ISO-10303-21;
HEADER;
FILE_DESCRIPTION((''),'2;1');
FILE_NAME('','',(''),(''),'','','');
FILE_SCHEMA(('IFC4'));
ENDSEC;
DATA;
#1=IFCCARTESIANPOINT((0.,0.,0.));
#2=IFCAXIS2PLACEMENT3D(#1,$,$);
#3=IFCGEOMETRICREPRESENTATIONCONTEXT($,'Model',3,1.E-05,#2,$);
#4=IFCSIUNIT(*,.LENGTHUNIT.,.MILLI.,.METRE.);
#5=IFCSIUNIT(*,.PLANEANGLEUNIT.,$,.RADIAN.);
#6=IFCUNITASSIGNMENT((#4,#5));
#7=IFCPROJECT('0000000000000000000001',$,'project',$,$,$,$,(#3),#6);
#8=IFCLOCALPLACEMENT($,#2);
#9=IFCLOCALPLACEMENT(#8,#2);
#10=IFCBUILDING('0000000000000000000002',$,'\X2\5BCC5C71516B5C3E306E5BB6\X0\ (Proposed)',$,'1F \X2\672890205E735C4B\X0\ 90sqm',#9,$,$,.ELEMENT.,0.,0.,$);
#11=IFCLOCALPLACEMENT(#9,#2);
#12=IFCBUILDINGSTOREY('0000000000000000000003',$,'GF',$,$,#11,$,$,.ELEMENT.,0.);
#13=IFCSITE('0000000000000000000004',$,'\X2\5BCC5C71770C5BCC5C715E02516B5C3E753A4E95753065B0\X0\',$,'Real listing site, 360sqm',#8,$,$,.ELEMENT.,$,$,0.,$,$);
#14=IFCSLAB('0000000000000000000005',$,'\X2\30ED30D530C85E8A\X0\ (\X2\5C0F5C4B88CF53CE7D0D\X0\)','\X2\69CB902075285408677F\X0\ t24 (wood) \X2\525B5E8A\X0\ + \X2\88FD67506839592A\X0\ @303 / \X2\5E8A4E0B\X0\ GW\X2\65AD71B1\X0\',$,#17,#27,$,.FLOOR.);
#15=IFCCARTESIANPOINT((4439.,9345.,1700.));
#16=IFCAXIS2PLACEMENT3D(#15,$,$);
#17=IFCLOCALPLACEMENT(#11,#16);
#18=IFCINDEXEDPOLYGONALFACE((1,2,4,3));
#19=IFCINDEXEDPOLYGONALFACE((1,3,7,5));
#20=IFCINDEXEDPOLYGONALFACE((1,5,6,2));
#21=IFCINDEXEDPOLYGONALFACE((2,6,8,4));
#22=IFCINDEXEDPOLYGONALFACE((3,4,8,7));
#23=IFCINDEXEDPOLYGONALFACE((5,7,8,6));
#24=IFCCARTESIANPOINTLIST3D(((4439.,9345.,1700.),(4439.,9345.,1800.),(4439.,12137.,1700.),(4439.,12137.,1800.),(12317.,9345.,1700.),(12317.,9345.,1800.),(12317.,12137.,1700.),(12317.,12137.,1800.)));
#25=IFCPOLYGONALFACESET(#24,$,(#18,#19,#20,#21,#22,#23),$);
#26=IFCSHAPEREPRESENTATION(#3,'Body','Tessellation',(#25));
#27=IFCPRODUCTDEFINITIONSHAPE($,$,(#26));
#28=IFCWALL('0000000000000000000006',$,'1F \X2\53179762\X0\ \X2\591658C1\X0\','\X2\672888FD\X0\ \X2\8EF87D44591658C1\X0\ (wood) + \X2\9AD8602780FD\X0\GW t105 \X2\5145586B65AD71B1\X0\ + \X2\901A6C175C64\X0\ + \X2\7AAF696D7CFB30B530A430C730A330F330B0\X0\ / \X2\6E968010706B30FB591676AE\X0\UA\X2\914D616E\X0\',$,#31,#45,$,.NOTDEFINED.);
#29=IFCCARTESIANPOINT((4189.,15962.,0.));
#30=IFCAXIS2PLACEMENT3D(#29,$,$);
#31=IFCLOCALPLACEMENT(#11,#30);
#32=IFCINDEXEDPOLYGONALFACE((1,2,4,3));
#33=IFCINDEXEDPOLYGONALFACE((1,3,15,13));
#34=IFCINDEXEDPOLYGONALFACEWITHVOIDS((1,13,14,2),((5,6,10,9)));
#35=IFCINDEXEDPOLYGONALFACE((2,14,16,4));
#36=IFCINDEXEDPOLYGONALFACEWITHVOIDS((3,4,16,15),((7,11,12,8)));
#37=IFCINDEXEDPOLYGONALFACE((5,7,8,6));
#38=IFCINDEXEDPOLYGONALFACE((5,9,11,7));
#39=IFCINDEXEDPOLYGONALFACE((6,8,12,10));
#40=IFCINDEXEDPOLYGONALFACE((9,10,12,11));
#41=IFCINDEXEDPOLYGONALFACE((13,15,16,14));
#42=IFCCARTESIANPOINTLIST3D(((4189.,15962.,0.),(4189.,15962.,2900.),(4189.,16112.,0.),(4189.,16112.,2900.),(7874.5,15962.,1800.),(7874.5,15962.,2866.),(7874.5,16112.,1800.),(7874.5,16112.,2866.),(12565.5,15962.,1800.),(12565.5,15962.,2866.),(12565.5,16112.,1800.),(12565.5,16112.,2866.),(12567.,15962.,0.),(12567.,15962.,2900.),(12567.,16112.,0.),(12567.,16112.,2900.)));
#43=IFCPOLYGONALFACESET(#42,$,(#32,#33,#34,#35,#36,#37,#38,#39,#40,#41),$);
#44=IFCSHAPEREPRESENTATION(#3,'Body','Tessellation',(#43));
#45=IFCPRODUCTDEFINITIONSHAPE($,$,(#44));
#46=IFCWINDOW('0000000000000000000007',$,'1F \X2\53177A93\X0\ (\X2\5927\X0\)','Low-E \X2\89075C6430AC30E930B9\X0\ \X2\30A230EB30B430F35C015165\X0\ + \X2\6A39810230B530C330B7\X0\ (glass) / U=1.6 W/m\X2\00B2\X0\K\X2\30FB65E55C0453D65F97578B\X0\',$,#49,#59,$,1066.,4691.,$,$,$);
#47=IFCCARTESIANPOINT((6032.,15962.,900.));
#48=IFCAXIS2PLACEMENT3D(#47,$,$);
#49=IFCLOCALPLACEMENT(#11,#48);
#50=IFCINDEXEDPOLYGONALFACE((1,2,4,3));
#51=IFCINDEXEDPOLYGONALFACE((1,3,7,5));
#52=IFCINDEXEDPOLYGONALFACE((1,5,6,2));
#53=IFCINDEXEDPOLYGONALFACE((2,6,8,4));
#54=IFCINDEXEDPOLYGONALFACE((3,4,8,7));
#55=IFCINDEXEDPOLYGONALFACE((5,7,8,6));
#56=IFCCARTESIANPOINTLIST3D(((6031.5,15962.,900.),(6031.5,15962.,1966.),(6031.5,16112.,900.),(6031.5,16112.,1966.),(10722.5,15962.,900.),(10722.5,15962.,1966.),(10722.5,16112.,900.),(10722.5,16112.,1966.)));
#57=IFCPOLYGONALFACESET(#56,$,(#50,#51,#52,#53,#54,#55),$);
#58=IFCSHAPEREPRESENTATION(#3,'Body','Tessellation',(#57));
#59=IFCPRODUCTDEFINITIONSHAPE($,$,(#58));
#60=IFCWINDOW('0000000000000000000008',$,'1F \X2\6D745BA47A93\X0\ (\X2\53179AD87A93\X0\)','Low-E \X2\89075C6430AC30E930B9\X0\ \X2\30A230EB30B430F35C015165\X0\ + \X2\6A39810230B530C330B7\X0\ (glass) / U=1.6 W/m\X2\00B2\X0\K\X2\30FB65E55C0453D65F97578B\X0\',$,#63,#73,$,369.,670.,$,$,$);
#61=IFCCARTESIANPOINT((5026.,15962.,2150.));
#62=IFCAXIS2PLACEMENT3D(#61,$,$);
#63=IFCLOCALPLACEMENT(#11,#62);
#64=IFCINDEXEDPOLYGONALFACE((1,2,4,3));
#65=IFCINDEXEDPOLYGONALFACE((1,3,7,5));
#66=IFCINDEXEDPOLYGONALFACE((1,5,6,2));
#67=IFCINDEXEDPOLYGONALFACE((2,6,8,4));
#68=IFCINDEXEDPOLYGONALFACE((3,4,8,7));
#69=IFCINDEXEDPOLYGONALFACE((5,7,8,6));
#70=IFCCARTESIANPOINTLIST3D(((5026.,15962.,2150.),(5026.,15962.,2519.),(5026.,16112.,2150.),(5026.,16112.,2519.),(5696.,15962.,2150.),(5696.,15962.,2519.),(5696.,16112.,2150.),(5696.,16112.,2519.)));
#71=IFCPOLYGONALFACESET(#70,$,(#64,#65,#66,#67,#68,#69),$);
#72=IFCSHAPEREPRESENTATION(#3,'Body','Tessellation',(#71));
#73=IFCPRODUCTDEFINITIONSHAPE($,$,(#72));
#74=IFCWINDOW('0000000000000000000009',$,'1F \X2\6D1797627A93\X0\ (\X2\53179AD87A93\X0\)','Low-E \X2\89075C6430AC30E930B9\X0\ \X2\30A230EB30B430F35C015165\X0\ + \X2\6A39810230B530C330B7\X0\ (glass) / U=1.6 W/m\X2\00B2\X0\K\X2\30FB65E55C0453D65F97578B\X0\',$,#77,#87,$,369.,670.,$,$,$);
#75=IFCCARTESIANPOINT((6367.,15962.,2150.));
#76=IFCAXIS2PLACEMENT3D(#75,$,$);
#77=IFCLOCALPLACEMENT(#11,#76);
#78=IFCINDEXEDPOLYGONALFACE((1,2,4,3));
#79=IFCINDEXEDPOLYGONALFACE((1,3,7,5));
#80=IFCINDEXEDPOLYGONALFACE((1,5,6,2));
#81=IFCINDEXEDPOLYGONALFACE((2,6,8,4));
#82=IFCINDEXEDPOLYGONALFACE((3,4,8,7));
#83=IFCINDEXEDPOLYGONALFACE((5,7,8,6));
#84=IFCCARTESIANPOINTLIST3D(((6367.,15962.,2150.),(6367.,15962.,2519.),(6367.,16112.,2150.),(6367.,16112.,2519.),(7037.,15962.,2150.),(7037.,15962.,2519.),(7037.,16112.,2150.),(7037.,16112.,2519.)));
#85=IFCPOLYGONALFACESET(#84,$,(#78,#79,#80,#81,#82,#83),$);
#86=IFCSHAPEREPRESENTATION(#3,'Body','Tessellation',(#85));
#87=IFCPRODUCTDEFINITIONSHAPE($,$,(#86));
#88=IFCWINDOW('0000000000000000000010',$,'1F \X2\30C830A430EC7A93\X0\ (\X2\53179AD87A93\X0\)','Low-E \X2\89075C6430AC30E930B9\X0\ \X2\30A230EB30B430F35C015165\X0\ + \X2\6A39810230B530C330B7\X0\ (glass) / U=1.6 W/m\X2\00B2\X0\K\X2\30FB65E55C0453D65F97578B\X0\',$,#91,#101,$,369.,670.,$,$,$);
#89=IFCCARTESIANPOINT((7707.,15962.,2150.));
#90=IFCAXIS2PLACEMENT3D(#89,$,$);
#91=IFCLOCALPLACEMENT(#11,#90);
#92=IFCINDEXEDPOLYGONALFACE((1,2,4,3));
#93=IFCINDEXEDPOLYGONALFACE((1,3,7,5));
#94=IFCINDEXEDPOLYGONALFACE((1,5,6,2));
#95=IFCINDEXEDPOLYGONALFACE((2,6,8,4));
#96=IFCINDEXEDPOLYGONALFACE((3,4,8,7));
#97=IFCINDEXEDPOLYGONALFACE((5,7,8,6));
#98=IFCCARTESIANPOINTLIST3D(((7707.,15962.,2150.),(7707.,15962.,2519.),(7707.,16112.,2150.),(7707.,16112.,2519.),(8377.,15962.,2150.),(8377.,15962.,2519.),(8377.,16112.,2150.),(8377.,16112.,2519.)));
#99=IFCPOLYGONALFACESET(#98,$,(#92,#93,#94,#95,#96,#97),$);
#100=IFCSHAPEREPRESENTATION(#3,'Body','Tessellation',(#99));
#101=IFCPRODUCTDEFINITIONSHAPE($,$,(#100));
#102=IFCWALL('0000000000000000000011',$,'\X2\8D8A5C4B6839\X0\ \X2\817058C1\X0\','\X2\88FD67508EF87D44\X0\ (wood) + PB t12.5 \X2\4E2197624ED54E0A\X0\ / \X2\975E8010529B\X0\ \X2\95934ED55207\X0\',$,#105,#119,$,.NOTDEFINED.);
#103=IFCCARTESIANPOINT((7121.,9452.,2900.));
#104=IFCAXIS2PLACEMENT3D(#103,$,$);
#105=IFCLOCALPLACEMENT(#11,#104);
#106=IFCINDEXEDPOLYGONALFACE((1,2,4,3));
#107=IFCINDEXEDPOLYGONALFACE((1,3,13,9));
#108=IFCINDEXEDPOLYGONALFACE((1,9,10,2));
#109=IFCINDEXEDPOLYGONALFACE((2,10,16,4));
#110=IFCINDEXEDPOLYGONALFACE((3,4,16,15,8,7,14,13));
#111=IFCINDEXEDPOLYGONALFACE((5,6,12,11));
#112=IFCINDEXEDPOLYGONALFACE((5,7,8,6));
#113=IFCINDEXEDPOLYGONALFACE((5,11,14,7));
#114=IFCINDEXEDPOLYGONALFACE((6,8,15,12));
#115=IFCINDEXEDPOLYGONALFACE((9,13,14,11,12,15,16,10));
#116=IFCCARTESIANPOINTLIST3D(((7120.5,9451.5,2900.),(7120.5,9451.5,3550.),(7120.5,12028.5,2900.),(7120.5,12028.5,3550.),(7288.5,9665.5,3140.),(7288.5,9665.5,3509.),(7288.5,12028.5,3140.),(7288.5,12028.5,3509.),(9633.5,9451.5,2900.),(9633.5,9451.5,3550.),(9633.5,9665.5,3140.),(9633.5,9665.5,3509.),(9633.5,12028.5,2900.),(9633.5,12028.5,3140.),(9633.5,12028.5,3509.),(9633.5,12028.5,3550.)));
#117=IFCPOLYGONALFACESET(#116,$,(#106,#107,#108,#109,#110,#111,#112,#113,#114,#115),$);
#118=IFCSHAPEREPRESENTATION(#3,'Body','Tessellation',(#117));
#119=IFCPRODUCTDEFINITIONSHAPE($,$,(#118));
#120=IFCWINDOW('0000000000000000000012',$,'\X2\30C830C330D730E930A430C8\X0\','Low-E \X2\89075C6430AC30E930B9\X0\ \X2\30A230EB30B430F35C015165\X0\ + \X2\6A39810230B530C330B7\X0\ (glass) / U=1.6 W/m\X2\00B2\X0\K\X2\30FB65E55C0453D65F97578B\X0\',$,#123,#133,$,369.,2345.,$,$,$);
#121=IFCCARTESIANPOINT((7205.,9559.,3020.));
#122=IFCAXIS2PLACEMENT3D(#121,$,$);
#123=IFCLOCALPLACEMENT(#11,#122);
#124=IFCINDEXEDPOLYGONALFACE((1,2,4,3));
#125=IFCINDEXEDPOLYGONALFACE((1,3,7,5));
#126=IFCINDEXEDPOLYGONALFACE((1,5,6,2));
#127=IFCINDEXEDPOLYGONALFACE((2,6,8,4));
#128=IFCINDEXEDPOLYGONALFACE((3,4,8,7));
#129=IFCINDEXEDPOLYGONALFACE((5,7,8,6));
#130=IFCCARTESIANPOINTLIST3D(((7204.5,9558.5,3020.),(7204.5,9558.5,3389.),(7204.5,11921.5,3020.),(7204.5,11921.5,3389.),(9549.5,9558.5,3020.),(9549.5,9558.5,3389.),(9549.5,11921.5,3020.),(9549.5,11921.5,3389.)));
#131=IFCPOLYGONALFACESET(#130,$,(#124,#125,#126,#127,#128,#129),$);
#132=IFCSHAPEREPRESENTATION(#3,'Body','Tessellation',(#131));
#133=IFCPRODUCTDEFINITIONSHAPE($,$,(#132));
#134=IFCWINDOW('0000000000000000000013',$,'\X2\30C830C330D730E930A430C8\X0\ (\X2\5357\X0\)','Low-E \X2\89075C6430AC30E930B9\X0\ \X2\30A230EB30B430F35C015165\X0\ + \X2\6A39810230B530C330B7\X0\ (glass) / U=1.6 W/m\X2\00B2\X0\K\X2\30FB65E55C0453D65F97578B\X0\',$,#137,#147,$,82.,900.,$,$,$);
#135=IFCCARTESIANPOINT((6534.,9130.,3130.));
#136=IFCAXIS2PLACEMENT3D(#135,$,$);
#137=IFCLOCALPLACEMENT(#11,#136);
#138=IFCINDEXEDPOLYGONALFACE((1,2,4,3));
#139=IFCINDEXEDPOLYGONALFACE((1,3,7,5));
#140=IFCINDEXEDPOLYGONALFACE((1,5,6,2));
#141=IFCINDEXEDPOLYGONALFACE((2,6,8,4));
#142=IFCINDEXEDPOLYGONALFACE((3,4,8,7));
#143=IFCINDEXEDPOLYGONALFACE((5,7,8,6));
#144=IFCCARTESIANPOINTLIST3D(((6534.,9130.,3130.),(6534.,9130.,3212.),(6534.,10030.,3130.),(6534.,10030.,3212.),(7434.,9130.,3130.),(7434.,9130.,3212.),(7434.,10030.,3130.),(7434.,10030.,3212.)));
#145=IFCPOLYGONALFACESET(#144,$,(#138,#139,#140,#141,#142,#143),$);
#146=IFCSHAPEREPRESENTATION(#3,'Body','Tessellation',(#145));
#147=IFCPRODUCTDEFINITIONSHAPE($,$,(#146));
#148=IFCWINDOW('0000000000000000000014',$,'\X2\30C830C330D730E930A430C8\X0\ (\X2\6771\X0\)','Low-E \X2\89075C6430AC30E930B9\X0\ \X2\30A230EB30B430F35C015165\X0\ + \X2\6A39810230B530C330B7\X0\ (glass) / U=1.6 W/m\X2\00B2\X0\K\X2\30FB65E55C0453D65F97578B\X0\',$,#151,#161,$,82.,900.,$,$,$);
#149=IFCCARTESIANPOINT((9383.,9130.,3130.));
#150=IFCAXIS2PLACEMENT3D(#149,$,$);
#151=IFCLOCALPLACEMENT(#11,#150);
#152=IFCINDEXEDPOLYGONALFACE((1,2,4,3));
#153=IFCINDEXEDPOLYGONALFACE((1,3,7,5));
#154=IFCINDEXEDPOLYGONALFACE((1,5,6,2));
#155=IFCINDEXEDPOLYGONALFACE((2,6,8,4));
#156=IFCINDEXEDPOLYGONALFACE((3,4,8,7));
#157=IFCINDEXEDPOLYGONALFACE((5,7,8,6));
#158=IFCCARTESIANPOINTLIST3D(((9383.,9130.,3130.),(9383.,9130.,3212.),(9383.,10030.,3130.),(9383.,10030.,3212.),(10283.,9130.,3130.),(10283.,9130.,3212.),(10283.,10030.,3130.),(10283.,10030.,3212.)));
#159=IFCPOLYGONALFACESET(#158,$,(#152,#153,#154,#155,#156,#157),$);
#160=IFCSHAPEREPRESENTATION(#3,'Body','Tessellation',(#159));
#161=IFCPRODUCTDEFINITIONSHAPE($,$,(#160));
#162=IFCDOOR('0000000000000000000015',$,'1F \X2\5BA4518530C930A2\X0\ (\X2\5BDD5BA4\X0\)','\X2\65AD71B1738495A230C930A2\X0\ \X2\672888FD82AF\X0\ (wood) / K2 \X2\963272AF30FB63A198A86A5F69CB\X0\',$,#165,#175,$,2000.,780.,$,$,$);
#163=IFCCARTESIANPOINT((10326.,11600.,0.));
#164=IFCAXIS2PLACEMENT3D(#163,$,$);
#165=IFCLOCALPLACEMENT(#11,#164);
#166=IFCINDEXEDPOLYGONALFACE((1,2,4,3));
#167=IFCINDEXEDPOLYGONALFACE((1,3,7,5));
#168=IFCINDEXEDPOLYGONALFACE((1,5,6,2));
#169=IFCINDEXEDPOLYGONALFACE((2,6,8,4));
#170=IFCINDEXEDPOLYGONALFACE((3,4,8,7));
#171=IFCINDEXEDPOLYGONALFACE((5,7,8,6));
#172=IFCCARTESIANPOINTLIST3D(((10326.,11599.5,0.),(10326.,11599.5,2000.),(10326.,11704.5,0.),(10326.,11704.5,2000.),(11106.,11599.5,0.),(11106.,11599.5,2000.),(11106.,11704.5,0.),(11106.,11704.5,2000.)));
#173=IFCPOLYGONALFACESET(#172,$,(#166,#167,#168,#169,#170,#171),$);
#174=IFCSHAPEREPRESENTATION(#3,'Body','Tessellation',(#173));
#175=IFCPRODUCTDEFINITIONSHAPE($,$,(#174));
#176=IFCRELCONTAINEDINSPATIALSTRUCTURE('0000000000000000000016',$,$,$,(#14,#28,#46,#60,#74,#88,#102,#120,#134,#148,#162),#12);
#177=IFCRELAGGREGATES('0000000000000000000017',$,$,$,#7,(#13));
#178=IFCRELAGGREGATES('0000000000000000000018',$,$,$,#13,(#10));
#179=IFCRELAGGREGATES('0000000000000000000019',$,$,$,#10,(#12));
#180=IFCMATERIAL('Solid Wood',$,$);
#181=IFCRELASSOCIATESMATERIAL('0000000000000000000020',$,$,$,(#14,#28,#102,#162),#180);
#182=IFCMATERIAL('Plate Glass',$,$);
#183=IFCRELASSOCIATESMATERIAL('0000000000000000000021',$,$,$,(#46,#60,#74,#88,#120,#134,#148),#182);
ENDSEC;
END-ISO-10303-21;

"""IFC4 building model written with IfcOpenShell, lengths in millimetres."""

from ifc_helpers import new_model, si_unit, frame, frame_2d, origin, place, context, project, spatial, rectangle, extrude, material, element, fill, save


model = new_model("IFC4")

# Units and contexts
model_context = context("Model", 3, precision=1e-05, world=origin())
ifc_project = project(units=[si_unit("LENGTHUNIT", "METRE", prefix="MILLI"), si_unit("PLANEANGLEUNIT", "RADIAN")], contexts=[model_context])

# Site, building, storey
site_placement = place(None, origin())
site = spatial("IfcSite", under=ifc_project, at=site_placement, Name="富山県富山市八尾町井田新", ObjectType="Real listing site, 360sqm", CompositionType="ELEMENT", RefElevation=0.0)
building_placement = place(site_placement, origin())
building = spatial("IfcBuilding", under=site, at=building_placement, Name="富山八尾の家 (Proposed)", ObjectType="1F 木造平屋 90sqm", CompositionType="ELEMENT", ElevationOfRefHeight=0.0, ElevationOfTerrain=0.0)
storey_placement = place(building_placement, origin())
storey = spatial("IfcBuildingStorey", under=building, at=storey_placement, Name="GF", CompositionType="ELEMENT", Elevation=0.0)

# Slab
ifc_material_1 = material(Name="Solid Wood")
slab_placement = place(storey_placement, frame((4439.0, 9345.0, 1700.0)))
element("IfcSlab", 1, at=slab_placement, inside=storey, material=ifc_material_1, Name="ロフト床 (小屋裏収納)", Description="構造用合板 t24 (wood) 剛床 + 製材根太 @303 / 床下 GW断熱", PredefinedType="FLOOR", context=model_context, shape_type="SweptSolid", body=[
    extrude(rectangle(XDim=7878.0, YDim=2792.0, at=frame_2d((3939.0, 1396.0))), frame((4439.0, 9345.0, 1700.0)), (0.0, 0.0, 1.0), 100.0),
])

# Wall, openings, windows
wall_1_placement = place(storey_placement, frame((4189.0, 15962.0, 0.0)))
wall_1 = element("IfcWall", 2, at=wall_1_placement, inside=storey, material=ifc_material_1, Name="1F 北面 外壁", Description="木製 軸組外壁 (wood) + 高性能GW t105 充填断熱 + 通気層 + 窯業系サイディング / 準耐火・外皮UA配慮", PredefinedType="NOTDEFINED", context=model_context, shape_type="SweptSolid", body=[
    extrude(rectangle(XDim=8378.0, YDim=150.0, at=frame_2d((4189.0, 75.0))), frame((4189.0, 15962.0, 0.0)), (0.0, 0.0, 1.0), 2900.0),
])
opening_1_placement = place(storey_placement, frame((6032.0, 15962.0, 900.0)))
opening_1 = element("IfcOpeningElement", 3, at=opening_1_placement, cuts=wall_1, PredefinedType="NOTDEFINED", context=model_context, shape_type="SweptSolid", body=[
    extrude(rectangle(XDim=4691.0, YDim=150.0, at=frame_2d((2345.0, 75.0))), frame((6032.0, 15962.0, 900.0)), (0.0, 0.0, 1.0), 1066.0),
])
opening_2_placement = place(storey_placement, frame((5026.0, 15962.0, 2150.0)))
opening_2 = element("IfcOpeningElement", 4, at=opening_2_placement, cuts=wall_1, PredefinedType="NOTDEFINED", context=model_context, shape_type="SweptSolid", body=[
    extrude(rectangle(XDim=670.0, YDim=150.0, at=frame_2d((335.0, 75.0))), frame((5026.0, 15962.0, 2150.0)), (0.0, 0.0, 1.0), 369.0),
])
opening_3_placement = place(storey_placement, frame((6367.0, 15962.0, 2150.0)))
opening_3 = element("IfcOpeningElement", 5, at=opening_3_placement, cuts=wall_1, PredefinedType="NOTDEFINED", context=model_context, shape_type="SweptSolid", body=[
    extrude(rectangle(XDim=670.0, YDim=150.0, at=frame_2d((335.0, 75.0))), frame((6367.0, 15962.0, 2150.0)), (0.0, 0.0, 1.0), 369.0),
])
opening_4_placement = place(storey_placement, frame((7707.0, 15962.0, 2150.0)))
opening_4 = element("IfcOpeningElement", 6, at=opening_4_placement, cuts=wall_1, PredefinedType="NOTDEFINED", context=model_context, shape_type="SweptSolid", body=[
    extrude(rectangle(XDim=670.0, YDim=150.0, at=frame_2d((335.0, 75.0))), frame((7707.0, 15962.0, 2150.0)), (0.0, 0.0, 1.0), 369.0),
])
ifc_material_2 = material(Name="Plate Glass")
window_1_placement = place(storey_placement, frame((6032.0, 15962.0, 900.0)))
window_1 = element("IfcWindow", 7, at=window_1_placement, inside=storey, material=ifc_material_2, Name="1F 北窓 (大)", Description="Low-E 複層ガラス アルゴン封入 + 樹脂サッシ (glass) / U=1.6 W/m²K・日射取得型", OverallHeight=1066.0, OverallWidth=4691.0, context=model_context, shape_type="SweptSolid", body=[
    extrude(rectangle(XDim=4691.0, YDim=150.0, at=frame_2d((2345.0, 75.0))), frame((6032.0, 15962.0, 900.0)), (0.0, 0.0, 1.0), 1066.0),
])
fill(opening_1, window_1)
window_2_placement = place(storey_placement, frame((5026.0, 15962.0, 2150.0)))
window_2 = element("IfcWindow", 8, at=window_2_placement, inside=storey, material=ifc_material_2, Name="1F 浴室窓 (北高窓)", Description="Low-E 複層ガラス アルゴン封入 + 樹脂サッシ (glass) / U=1.6 W/m²K・日射取得型", OverallHeight=369.0, OverallWidth=670.0, context=model_context, shape_type="SweptSolid", body=[
    extrude(rectangle(XDim=670.0, YDim=150.0, at=frame_2d((335.0, 75.0))), frame((5026.0, 15962.0, 2150.0)), (0.0, 0.0, 1.0), 369.0),
])
fill(opening_2, window_2)
window_3_placement = place(storey_placement, frame((6367.0, 15962.0, 2150.0)))
window_3 = element("IfcWindow", 9, at=window_3_placement, inside=storey, material=ifc_material_2, Name="1F 洗面窓 (北高窓)", Description="Low-E 複層ガラス アルゴン封入 + 樹脂サッシ (glass) / U=1.6 W/m²K・日射取得型", OverallHeight=369.0, OverallWidth=670.0, context=model_context, shape_type="SweptSolid", body=[
    extrude(rectangle(XDim=670.0, YDim=150.0, at=frame_2d((335.0, 75.0))), frame((6367.0, 15962.0, 2150.0)), (0.0, 0.0, 1.0), 369.0),
])
fill(opening_3, window_3)
window_4_placement = place(storey_placement, frame((7707.0, 15962.0, 2150.0)))
window_4 = element("IfcWindow", 10, at=window_4_placement, inside=storey, material=ifc_material_2, Name="1F トイレ窓 (北高窓)", Description="Low-E 複層ガラス アルゴン封入 + 樹脂サッシ (glass) / U=1.6 W/m²K・日射取得型", OverallHeight=369.0, OverallWidth=670.0, context=model_context, shape_type="SweptSolid", body=[
    extrude(rectangle(XDim=670.0, YDim=150.0, at=frame_2d((335.0, 75.0))), frame((7707.0, 15962.0, 2150.0)), (0.0, 0.0, 1.0), 369.0),
])
fill(opening_4, window_4)

# Wall, openings, windows
wall_2_placement = place(storey_placement, frame((7121.0, 9452.0, 2900.0)))
wall_2 = element("IfcWall", 11, at=wall_2_placement, inside=storey, material=ifc_material_1, Name="越屋根 腰壁", Description="製材軸組 (wood) + PB t12.5 両面仕上 / 非耐力 間仕切", PredefinedType="NOTDEFINED", context=model_context, shape_type="SweptSolid", body=[
    extrude(rectangle(XDim=2513.0, YDim=2577.0, at=frame_2d((1256.0, 1288.0))), frame((7121.0, 9452.0, 2900.0)), (0.0, 0.0, 1.0), 650.0),
])
opening_5_placement = place(storey_placement, frame((7205.0, 9559.0, 3020.0)))
opening_5 = element("IfcOpeningElement", 12, at=opening_5_placement, cuts=wall_2, PredefinedType="NOTDEFINED", context=model_context, shape_type="SweptSolid", body=[
    extrude(rectangle(XDim=2345.0, YDim=2363.0, at=frame_2d((1172.0, 1181.0))), frame((7205.0, 9559.0, 3020.0)), (0.0, 0.0, 1.0), 369.0),
])
opening_6_placement = place(storey_placement, frame((6534.0, 9130.0, 3130.0)))
opening_6 = element("IfcOpeningElement", 13, at=opening_6_placement, cuts=wall_2, PredefinedType="NOTDEFINED", context=model_context, shape_type="SweptSolid", body=[
    extrude(rectangle(XDim=900.0, YDim=900.0, at=frame_2d((450.0, 450.0))), frame((6534.0, 9130.0, 3130.0)), (0.0, 0.0, 1.0), 82.0),
])
opening_7_placement = place(storey_placement, frame((9383.0, 9130.0, 3130.0)))
opening_7 = element("IfcOpeningElement", 14, at=opening_7_placement, cuts=wall_2, PredefinedType="NOTDEFINED", context=model_context, shape_type="SweptSolid", body=[
    extrude(rectangle(XDim=900.0, YDim=900.0, at=frame_2d((450.0, 450.0))), frame((9383.0, 9130.0, 3130.0)), (0.0, 0.0, 1.0), 82.0),
])
window_5_placement = place(storey_placement, frame((7205.0, 9559.0, 3020.0)))
window_5 = element("IfcWindow", 15, at=window_5_placement, inside=storey, material=ifc_material_2, Name="トップライト", Description="Low-E 複層ガラス アルゴン封入 + 樹脂サッシ (glass) / U=1.6 W/m²K・日射取得型", OverallHeight=369.0, OverallWidth=2345.0, context=model_context, shape_type="SweptSolid", body=[
    extrude(rectangle(XDim=2345.0, YDim=2363.0, at=frame_2d((1172.0, 1181.0))), frame((7205.0, 9559.0, 3020.0)), (0.0, 0.0, 1.0), 369.0),
])
fill(opening_5, window_5)
window_6_placement = place(storey_placement, frame((6534.0, 9130.0, 3130.0)))
window_6 = element("IfcWindow", 16, at=window_6_placement, inside=storey, material=ifc_material_2, Name="トップライト (南)", Description="Low-E 複層ガラス アルゴン封入 + 樹脂サッシ (glass) / U=1.6 W/m²K・日射取得型", OverallHeight=82.0, OverallWidth=900.0, context=model_context, shape_type="SweptSolid", body=[
    extrude(rectangle(XDim=900.0, YDim=900.0, at=frame_2d((450.0, 450.0))), frame((6534.0, 9130.0, 3130.0)), (0.0, 0.0, 1.0), 82.0),
])
fill(opening_6, window_6)
window_7_placement = place(storey_placement, frame((9383.0, 9130.0, 3130.0)))
window_7 = element("IfcWindow", 17, at=window_7_placement, inside=storey, material=ifc_material_2, Name="トップライト (東)", Description="Low-E 複層ガラス アルゴン封入 + 樹脂サッシ (glass) / U=1.6 W/m²K・日射取得型", OverallHeight=82.0, OverallWidth=900.0, context=model_context, shape_type="SweptSolid", body=[
    extrude(rectangle(XDim=900.0, YDim=900.0, at=frame_2d((450.0, 450.0))), frame((9383.0, 9130.0, 3130.0)), (0.0, 0.0, 1.0), 82.0),
])
fill(opening_7, window_7)

# Door
door_1_placement = place(storey_placement, frame((10326.0, 11600.0, 0.0)))
element("IfcDoor", 18, at=door_1_placement, inside=storey, material=ifc_material_1, Name="1F 室内ドア (寝室)", Description="断熱玄関ドア 木製芯 (wood) / K2 防犯・採風機構", OverallHeight=2000.0, OverallWidth=780.0, context=model_context, shape_type="SweptSolid", body=[
    extrude(rectangle(XDim=780.0, YDim=105.0, at=frame_2d((390.0, 52.0))), frame((10326.0, 11600.0, 0.0)), (0.0, 0.0, 1.0), 2000.0),
])

save(model, "model.ifc")
